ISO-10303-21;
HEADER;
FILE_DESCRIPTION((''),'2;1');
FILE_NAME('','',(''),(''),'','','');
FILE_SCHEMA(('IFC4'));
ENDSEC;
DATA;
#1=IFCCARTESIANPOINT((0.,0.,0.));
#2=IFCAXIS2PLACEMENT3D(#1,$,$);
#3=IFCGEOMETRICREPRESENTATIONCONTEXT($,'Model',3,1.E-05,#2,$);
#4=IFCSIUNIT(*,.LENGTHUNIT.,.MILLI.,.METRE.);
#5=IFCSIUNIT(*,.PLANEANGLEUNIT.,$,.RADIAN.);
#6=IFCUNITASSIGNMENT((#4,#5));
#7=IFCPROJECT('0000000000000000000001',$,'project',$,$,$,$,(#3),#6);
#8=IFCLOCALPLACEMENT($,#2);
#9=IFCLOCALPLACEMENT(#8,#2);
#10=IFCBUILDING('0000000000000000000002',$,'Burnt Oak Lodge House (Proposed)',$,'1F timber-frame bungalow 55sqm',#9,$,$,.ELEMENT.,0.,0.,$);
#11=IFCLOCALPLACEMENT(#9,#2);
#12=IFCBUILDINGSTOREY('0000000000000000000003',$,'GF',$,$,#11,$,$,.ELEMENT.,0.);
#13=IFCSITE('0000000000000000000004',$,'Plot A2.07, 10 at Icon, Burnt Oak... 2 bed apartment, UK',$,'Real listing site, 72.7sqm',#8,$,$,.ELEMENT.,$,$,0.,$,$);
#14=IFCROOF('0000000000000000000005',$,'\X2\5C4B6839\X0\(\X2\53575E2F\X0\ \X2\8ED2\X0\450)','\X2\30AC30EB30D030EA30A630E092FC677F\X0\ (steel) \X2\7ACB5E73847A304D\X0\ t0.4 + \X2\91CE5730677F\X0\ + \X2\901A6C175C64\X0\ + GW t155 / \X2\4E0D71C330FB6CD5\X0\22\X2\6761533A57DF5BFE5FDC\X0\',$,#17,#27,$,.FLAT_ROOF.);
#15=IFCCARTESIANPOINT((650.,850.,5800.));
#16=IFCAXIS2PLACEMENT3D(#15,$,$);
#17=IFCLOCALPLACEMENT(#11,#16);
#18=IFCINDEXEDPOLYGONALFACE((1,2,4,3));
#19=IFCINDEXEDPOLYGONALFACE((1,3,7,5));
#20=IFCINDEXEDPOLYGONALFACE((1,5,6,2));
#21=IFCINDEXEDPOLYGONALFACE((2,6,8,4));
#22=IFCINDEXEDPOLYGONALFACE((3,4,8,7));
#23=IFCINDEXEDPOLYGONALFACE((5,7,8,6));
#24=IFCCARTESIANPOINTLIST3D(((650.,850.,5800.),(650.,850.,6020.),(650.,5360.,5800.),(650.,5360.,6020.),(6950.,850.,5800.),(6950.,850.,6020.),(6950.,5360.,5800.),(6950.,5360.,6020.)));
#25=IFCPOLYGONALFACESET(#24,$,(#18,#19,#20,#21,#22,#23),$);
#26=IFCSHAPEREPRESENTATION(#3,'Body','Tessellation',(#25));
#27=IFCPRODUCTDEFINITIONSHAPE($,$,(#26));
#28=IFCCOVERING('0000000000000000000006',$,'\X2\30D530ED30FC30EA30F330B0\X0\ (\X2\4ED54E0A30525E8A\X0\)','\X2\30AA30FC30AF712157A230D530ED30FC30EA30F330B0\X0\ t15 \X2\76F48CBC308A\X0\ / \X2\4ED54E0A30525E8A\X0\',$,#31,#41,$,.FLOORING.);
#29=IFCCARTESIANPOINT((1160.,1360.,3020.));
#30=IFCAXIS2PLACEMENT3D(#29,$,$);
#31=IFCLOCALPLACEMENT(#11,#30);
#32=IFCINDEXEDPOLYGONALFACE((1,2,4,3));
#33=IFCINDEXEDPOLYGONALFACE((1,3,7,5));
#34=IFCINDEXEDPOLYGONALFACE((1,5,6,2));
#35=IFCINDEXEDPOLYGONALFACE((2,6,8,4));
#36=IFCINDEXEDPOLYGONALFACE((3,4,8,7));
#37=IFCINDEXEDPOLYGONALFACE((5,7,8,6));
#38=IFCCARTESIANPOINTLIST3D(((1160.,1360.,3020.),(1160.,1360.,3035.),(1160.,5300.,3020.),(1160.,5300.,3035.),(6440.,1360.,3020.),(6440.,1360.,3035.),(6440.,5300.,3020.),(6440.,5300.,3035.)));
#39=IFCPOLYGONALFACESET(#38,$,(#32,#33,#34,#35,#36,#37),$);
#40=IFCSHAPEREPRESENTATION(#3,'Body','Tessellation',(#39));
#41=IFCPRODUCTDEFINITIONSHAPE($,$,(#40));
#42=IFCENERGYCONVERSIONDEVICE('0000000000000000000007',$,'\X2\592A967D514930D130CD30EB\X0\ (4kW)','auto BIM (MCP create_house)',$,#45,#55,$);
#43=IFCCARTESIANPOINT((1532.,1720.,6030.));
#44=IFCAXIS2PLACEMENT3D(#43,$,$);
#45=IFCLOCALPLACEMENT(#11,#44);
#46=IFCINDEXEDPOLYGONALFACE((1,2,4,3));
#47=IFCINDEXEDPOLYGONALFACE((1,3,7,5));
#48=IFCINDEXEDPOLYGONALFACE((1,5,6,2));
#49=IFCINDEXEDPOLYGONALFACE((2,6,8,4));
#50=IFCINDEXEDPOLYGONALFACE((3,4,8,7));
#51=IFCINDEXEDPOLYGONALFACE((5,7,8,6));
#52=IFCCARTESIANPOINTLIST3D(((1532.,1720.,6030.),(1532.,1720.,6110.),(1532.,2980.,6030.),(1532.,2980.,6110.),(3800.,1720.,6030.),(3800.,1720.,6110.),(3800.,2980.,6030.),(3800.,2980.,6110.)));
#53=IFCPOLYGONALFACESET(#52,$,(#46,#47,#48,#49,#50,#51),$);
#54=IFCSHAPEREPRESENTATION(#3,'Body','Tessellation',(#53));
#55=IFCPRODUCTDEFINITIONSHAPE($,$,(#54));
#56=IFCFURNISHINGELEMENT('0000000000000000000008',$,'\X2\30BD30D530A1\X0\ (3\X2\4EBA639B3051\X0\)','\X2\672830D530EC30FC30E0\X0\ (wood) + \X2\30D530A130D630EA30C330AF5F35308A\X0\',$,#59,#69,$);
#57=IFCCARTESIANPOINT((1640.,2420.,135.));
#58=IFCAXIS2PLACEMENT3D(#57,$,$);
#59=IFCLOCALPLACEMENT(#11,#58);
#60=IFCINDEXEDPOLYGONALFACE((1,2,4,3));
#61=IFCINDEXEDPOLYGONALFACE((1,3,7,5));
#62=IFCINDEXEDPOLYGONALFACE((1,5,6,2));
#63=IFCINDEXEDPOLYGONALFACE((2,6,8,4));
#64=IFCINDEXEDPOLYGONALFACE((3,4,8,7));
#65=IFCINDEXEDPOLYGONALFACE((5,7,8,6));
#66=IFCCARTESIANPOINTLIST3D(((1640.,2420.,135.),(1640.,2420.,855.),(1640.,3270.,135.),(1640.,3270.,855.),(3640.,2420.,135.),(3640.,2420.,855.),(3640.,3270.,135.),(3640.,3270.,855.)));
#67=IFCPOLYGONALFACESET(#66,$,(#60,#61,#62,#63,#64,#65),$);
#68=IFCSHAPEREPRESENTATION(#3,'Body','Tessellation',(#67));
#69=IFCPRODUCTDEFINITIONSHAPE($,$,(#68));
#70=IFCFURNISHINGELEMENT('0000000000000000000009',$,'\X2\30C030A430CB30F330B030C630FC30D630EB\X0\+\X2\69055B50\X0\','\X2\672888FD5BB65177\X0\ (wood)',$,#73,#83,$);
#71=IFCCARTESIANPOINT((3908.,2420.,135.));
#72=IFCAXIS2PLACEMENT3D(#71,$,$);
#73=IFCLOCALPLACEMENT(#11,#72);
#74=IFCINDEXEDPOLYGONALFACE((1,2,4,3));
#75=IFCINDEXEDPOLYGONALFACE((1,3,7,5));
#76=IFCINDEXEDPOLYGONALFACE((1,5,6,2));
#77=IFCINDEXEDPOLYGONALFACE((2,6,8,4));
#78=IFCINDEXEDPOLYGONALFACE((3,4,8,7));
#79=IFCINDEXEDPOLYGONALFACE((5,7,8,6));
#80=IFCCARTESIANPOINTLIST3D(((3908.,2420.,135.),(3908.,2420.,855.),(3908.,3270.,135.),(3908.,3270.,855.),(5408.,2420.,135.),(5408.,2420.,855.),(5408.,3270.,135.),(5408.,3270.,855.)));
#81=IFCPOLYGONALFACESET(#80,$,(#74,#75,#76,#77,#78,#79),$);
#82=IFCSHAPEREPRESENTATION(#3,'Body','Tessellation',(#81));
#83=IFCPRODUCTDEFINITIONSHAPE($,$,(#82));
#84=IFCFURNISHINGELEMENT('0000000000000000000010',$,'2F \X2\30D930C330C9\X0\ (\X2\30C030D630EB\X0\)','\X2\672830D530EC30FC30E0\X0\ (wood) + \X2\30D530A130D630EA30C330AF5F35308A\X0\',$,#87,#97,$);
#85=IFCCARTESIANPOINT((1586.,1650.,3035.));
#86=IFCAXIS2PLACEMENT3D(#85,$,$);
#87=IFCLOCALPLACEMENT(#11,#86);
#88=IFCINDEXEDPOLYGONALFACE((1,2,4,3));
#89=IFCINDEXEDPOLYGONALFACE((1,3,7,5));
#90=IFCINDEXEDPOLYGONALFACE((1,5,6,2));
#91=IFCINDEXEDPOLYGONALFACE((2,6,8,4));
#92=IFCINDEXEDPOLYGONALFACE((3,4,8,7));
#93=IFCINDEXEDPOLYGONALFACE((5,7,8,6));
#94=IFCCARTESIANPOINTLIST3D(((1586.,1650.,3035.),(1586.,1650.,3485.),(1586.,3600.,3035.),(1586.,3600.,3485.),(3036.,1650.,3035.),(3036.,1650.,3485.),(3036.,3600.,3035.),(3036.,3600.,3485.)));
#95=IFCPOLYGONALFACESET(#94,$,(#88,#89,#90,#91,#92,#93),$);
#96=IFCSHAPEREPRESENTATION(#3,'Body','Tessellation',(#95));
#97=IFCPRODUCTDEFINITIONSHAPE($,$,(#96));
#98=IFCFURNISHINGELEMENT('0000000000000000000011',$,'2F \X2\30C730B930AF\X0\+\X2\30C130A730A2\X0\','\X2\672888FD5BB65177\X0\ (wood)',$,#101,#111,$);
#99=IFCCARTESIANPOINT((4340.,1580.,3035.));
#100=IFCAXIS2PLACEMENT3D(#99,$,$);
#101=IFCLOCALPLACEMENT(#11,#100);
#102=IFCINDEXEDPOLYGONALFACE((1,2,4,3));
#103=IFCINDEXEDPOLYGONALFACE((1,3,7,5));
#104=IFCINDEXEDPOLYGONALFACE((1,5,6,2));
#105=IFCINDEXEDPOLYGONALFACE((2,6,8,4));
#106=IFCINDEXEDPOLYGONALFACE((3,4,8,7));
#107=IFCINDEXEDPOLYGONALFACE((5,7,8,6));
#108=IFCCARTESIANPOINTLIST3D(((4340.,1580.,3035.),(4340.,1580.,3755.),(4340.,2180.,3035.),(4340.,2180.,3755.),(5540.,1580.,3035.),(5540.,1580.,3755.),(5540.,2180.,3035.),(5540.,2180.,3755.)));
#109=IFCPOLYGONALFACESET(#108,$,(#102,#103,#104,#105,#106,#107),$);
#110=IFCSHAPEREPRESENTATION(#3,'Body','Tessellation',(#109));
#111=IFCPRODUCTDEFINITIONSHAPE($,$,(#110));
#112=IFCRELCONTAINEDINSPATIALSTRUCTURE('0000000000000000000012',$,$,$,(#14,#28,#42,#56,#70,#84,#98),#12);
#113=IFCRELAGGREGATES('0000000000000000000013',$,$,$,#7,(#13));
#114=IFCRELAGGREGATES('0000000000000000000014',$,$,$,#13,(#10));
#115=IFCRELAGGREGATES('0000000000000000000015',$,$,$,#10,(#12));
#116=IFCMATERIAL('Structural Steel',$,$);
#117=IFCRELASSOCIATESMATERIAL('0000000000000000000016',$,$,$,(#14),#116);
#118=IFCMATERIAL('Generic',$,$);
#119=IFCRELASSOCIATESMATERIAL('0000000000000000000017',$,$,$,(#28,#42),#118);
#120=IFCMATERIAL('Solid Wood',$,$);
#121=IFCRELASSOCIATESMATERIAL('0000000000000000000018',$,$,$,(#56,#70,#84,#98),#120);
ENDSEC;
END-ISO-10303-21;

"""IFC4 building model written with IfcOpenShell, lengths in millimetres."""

from ifc_helpers import new_model, si_unit, frame, frame_2d, origin, place, context, project, spatial, rectangle, extrude, material, element, save


model = new_model("IFC4")

# Units and contexts
model_context = context("Model", 3, precision=1e-05, world=origin())
ifc_project = project(units=[si_unit("LENGTHUNIT", "METRE", prefix="MILLI"), si_unit("PLANEANGLEUNIT", "RADIAN")], contexts=[model_context])

# Site, building, storey
site_placement = place(None, origin())
site = spatial("IfcSite", under=ifc_project, at=site_placement, Name="Plot A2.07, 10 at Icon, Burnt Oak... 2 bed apartment, UK", ObjectType="Real listing site, 72.7sqm", CompositionType="ELEMENT", RefElevation=0.0)
building_placement = place(site_placement, origin())
building = spatial("IfcBuilding", under=site, at=building_placement, Name="Burnt Oak Lodge House (Proposed)", ObjectType="1F timber-frame bungalow 55sqm", CompositionType="ELEMENT", ElevationOfRefHeight=0.0, ElevationOfTerrain=0.0)
storey_placement = place(building_placement, origin())
storey = spatial("IfcBuildingStorey", under=building, at=storey_placement, Name="GF", CompositionType="ELEMENT", Elevation=0.0)

# Shared definitions
ifc_material_1 = material(Name="Solid Wood")

# Shared definitions
ifc_material_2 = material(Name="Generic")

# Roof
ifc_material_3 = material(Name="Structural Steel")
for number, where, name in (
    (1, (650.0, 850.0, 5800.0), "屋根(南帯 軒450)"),
):
    element("IfcRoof", number, at=place(storey_placement, frame(where)), inside=storey, material=ifc_material_3, Name=name, Description="ガルバリウム鋼板 (steel) 立平葺き t0.4 + 野地板 + 通気層 + GW t155 / 不燃・法22条区域対応", PredefinedType="FLAT_ROOF", context=model_context, shape_type="SweptSolid", body=[
        extrude(rectangle(XDim=6300.0, YDim=4510.0, at=frame_2d((3150.0, 2255.0))), frame((650.0, 850.0, 5800.0)), (0.0, 0.0, 1.0), 220.0),
    ])

# Covering
covering_placement = place(storey_placement, frame((1160.0, 1360.0, 3020.0)))
element("IfcCovering", 2, at=covering_placement, inside=storey, material=ifc_material_2, Name="フローリング (仕上げ床)", Description="オーク無垢フローリング t15 直貼り / 仕上げ床", PredefinedType="FLOORING", context=model_context, shape_type="SweptSolid", body=[
    extrude(rectangle(XDim=5280.0, YDim=3940.0, at=frame_2d((2640.0, 1970.0))), frame((1160.0, 1360.0, 3020.0)), (0.0, 0.0, 1.0), 15.0),
])

# Energy conversion device
energy_conversion_device_placement = place(storey_placement, frame((1532.0, 1720.0, 6030.0)))
element("IfcEnergyConversionDevice", 3, at=energy_conversion_device_placement, inside=storey, material=ifc_material_2, Name="太陽光パネル (4kW)", Description="auto BIM (MCP create_house)", context=model_context, shape_type="SweptSolid", body=[
    extrude(rectangle(XDim=2268.0, YDim=1260.0, at=frame_2d((1134.0, 630.0))), frame((1532.0, 1720.0, 6030.0)), (0.0, 0.0, 1.0), 80.0),
])

# Furnishing elements
furnishing_1_placement = place(storey_placement, frame((1640.0, 2420.0, 135.0)))
element("IfcFurnishingElement", 4, at=furnishing_1_placement, inside=storey, material=ifc_material_1, Name="ソファ (3人掛け)", Description="木フレーム (wood) + ファブリック張り", context=model_context, shape_type="SweptSolid", body=[
    extrude(rectangle(XDim=2000.0, YDim=850.0, at=frame_2d((1000.0, 425.0))), frame((1640.0, 2420.0, 135.0)), (0.0, 0.0, 1.0), 720.0),
])
furnishing_2_placement = place(storey_placement, frame((3908.0, 2420.0, 135.0)))
element("IfcFurnishingElement", 5, at=furnishing_2_placement, inside=storey, material=ifc_material_1, Name="ダイニングテーブル+椅子", Description="木製家具 (wood)", context=model_context, shape_type="SweptSolid", body=[
    extrude(rectangle(XDim=1500.0, YDim=850.0, at=frame_2d((750.0, 425.0))), frame((3908.0, 2420.0, 135.0)), (0.0, 0.0, 1.0), 720.0),
])
furnishing_3_placement = place(storey_placement, frame((1586.0, 1650.0, 3035.0)))
element("IfcFurnishingElement", 6, at=furnishing_3_placement, inside=storey, material=ifc_material_1, Name="2F ベッド (ダブル)", Description="木フレーム (wood) + ファブリック張り", context=model_context, shape_type="SweptSolid", body=[
    extrude(rectangle(XDim=1450.0, YDim=1950.0, at=frame_2d((725.0, 975.0))), frame((1586.0, 1650.0, 3035.0)), (0.0, 0.0, 1.0), 450.0),
])
furnishing_4_placement = place(storey_placement, frame((4340.0, 1580.0, 3035.0)))
element("IfcFurnishingElement", 7, at=furnishing_4_placement, inside=storey, material=ifc_material_1, Name="2F デスク+チェア", Description="木製家具 (wood)", context=model_context, shape_type="SweptSolid", body=[
    extrude(rectangle(XDim=1200.0, YDim=600.0, at=frame_2d((600.0, 300.0))), frame((4340.0, 1580.0, 3035.0)), (0.0, 0.0, 1.0), 720.0),
])

save(model, "model.ifc")
